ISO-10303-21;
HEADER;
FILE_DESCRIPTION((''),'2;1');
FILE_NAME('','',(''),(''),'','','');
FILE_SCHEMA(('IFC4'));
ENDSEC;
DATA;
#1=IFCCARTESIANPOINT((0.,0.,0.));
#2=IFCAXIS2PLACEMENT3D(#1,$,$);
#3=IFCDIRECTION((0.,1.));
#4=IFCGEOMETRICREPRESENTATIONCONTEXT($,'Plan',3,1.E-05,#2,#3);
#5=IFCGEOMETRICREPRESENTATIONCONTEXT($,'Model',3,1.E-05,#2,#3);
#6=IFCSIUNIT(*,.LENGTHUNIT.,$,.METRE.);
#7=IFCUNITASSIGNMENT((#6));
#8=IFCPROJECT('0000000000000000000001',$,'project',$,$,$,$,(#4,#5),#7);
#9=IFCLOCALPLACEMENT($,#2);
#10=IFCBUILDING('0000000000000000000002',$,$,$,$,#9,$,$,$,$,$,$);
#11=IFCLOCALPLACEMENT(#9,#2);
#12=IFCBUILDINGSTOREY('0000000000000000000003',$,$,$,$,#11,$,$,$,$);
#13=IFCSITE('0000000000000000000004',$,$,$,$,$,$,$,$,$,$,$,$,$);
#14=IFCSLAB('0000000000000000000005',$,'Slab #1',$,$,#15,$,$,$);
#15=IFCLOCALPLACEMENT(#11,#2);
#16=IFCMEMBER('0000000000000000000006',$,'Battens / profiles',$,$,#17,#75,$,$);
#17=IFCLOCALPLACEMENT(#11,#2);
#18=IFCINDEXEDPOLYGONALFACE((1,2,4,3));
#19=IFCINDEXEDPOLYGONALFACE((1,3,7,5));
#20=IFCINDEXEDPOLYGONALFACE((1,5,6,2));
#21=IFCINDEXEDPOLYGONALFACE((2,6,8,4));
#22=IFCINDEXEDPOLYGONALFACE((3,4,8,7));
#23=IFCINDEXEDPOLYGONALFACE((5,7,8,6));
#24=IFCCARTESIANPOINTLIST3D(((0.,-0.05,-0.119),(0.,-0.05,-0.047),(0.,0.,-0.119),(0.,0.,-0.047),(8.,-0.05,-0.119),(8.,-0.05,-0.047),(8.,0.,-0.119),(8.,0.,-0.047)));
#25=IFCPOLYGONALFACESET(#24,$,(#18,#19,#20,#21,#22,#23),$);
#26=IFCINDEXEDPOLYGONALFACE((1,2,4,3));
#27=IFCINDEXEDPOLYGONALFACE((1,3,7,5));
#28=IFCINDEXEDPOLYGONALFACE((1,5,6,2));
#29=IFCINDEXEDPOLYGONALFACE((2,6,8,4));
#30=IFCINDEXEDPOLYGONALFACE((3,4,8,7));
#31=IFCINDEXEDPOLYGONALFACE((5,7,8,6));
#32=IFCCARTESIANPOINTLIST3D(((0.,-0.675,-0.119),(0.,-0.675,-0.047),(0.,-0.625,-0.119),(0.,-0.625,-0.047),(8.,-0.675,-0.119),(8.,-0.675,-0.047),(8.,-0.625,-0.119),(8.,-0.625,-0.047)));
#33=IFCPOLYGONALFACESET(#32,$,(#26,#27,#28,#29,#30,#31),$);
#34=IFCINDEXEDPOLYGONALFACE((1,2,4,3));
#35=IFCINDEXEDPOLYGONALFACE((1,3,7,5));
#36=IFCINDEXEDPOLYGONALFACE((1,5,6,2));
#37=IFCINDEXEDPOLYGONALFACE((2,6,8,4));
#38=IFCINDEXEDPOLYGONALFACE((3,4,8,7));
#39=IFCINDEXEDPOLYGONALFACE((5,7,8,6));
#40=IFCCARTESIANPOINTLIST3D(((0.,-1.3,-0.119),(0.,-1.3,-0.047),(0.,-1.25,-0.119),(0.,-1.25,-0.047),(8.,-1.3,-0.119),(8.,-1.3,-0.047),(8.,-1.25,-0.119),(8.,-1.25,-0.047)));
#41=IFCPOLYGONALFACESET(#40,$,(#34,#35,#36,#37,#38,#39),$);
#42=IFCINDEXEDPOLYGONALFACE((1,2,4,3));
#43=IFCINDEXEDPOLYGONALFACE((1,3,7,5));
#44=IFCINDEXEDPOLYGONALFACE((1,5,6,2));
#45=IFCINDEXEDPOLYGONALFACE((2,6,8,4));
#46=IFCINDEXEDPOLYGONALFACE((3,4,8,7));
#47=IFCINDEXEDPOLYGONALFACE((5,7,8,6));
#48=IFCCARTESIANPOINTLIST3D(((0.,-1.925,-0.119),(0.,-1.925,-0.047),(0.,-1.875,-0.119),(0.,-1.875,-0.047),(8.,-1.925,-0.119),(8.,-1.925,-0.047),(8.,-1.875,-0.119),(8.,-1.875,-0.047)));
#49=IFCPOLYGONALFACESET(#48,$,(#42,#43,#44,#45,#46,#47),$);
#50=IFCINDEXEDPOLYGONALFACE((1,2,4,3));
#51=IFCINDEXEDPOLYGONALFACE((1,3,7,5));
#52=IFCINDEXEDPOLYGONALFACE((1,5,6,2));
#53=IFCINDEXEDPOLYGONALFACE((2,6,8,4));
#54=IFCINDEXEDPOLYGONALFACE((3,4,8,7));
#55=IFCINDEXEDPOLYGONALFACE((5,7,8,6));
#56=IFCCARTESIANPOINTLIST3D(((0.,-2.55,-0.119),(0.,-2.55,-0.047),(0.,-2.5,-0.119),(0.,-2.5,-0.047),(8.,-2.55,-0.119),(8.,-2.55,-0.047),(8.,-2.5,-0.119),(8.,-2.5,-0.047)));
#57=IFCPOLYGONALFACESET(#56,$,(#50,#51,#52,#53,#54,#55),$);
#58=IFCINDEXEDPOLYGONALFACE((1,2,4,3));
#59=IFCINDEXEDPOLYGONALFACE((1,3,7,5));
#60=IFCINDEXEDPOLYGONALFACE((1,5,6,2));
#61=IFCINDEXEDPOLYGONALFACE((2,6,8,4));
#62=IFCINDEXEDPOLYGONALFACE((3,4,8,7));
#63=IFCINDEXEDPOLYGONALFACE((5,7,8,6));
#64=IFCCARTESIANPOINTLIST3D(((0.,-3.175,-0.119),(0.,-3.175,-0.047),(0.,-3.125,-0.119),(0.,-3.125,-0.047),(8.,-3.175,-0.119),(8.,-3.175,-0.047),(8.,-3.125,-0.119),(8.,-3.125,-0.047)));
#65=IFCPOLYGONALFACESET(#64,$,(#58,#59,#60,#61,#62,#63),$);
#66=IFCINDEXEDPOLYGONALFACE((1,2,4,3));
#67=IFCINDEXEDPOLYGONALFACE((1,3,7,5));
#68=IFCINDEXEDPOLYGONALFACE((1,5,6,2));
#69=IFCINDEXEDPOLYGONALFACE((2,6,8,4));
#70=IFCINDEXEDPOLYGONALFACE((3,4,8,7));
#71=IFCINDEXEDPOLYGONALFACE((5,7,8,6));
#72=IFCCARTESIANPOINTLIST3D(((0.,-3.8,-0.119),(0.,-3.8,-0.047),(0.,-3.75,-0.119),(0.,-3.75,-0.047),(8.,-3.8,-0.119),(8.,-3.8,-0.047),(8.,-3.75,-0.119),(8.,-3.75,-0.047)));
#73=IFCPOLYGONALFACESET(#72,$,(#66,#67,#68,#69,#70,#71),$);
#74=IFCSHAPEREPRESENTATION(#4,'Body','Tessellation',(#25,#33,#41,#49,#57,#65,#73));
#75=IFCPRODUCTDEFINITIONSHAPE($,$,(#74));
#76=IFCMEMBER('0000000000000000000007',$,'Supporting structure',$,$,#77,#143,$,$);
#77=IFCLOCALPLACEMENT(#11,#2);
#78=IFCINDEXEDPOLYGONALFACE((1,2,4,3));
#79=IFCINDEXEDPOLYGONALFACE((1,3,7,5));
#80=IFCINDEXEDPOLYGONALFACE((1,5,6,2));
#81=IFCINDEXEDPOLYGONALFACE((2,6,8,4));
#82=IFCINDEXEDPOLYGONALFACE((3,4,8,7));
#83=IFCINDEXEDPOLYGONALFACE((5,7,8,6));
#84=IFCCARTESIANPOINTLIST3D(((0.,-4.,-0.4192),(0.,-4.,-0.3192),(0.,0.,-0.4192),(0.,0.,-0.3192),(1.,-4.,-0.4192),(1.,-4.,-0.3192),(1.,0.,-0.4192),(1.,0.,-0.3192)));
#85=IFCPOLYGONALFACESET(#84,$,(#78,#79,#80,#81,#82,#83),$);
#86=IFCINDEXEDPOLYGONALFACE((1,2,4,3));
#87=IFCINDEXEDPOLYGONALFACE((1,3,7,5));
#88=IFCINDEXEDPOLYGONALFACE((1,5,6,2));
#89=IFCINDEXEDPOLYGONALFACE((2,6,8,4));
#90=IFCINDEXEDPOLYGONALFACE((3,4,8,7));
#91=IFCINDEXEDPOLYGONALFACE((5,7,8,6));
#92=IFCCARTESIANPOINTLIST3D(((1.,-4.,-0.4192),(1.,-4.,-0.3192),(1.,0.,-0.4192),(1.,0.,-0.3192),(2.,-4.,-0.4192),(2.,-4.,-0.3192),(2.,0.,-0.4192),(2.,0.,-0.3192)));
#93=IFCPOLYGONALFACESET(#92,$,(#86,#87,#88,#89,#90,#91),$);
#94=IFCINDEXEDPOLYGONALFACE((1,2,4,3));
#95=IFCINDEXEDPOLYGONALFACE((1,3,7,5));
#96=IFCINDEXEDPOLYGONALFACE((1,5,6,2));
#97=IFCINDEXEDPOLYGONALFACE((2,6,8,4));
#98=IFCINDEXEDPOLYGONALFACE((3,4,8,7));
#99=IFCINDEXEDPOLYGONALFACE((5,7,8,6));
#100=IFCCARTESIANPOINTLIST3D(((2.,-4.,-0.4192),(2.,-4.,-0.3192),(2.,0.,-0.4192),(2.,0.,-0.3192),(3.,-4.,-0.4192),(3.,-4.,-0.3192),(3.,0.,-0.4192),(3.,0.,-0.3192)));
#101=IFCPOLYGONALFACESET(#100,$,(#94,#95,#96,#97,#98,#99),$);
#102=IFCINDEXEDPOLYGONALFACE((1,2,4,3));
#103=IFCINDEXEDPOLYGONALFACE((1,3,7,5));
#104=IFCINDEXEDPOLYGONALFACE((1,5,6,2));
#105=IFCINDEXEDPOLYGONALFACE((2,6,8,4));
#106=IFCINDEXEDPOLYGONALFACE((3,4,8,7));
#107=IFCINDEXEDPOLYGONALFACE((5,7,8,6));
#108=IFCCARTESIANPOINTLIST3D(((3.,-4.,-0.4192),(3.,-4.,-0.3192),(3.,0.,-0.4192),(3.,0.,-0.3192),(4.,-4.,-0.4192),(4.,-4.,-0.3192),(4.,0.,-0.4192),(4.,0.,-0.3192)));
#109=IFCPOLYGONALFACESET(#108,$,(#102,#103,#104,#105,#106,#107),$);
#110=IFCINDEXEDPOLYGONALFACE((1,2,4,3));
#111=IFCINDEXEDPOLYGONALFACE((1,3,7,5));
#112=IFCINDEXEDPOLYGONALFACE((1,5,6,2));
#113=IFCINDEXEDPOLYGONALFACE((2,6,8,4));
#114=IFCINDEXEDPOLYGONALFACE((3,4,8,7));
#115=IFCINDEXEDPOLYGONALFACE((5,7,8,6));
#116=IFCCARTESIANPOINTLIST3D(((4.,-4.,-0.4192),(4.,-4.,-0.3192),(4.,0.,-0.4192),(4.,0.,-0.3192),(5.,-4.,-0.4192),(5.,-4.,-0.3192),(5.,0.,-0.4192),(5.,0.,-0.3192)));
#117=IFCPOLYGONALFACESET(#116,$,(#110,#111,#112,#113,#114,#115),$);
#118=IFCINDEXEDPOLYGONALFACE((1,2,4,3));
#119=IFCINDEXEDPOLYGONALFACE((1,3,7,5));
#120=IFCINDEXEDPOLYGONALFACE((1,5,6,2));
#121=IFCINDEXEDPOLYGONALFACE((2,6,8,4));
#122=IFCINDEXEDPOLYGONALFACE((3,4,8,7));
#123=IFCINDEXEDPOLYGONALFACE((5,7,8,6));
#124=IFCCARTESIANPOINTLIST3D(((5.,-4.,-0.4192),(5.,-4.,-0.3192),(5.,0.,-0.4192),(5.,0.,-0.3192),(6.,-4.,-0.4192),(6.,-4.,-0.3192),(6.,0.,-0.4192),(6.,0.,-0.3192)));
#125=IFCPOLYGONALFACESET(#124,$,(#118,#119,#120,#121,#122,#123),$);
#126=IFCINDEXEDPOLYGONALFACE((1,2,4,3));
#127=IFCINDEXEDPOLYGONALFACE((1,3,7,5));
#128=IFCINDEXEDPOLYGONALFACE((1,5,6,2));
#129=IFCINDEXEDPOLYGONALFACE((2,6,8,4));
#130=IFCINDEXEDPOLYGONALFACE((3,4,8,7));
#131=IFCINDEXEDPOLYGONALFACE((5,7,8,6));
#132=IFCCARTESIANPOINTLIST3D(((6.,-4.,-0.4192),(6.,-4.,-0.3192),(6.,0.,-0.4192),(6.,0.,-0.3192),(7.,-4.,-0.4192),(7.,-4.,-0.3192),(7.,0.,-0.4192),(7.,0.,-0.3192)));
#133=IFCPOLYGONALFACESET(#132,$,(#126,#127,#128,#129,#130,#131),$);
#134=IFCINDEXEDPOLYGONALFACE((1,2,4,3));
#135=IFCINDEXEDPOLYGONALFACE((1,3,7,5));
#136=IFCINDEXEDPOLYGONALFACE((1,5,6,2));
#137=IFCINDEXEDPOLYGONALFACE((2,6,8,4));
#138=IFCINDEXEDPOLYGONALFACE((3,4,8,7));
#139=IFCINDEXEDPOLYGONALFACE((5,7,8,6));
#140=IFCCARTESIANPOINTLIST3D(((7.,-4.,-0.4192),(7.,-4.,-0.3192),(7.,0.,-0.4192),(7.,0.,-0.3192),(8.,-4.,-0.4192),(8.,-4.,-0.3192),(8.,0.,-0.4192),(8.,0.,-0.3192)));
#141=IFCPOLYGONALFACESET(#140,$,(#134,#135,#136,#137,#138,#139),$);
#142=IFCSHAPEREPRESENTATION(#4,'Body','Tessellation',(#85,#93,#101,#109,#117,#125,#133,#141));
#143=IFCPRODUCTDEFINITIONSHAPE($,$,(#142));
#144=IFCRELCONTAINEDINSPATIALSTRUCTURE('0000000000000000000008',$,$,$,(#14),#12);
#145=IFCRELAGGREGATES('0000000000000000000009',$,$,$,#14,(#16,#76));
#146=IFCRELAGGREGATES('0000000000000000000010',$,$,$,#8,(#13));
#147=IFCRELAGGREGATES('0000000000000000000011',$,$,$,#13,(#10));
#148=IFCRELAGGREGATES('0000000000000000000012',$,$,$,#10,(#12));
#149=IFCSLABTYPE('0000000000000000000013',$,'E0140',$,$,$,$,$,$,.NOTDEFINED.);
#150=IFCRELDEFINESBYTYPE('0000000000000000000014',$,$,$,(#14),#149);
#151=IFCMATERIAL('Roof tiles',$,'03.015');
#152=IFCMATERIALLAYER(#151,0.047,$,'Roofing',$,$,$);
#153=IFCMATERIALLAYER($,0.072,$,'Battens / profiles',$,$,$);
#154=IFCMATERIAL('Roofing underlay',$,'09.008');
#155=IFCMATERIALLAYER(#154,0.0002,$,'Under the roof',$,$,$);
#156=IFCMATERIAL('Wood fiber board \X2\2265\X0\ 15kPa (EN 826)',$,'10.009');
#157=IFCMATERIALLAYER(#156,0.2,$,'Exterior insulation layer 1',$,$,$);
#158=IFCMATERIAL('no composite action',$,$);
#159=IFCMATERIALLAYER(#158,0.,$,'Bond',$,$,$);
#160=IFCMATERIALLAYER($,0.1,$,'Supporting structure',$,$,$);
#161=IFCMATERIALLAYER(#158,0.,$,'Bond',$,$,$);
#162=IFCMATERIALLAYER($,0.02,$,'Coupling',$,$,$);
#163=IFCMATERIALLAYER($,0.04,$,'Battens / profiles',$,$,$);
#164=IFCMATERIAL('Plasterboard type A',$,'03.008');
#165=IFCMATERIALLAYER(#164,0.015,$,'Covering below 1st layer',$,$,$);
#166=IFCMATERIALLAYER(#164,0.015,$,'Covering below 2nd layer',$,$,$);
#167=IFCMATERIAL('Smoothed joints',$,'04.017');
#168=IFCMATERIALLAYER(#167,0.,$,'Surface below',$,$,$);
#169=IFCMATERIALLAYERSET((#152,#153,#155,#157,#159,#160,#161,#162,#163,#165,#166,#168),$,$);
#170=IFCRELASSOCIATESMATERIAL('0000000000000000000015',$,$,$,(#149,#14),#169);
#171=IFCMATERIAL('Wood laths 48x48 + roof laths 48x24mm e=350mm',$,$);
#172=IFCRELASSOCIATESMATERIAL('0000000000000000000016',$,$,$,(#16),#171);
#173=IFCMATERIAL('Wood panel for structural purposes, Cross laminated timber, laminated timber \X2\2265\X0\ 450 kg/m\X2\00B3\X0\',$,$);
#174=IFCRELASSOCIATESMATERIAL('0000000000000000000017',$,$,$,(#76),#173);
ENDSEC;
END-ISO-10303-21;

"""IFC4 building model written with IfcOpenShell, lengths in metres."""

from ifc_helpers import new_model, si_unit, direction, frame, frame_2d, origin, place, context, project, spatial, rectangle, extrude, material, layer, layer_set, type_object, element, aggregate, save


model = new_model("IFC4")

# Units and contexts
plan_context = context("Plan", 3, precision=1e-05, world=origin(), true_north=direction((0.0, 1.0)))
model_context = context("Model", 3, precision=1e-05, world=origin(), true_north=direction((0.0, 1.0)))
ifc_project = project(units=[si_unit("LENGTHUNIT", "METRE")], contexts=[plan_context, model_context])

# Site, building, storey
site = spatial("IfcSite", under=ifc_project)
building_placement = place(None, origin())
building = spatial("IfcBuilding", under=site, at=building_placement)
storey_placement = place(building_placement, origin())
storey = spatial("IfcBuildingStorey", under=building, at=storey_placement)

# Slab, members
ifc_material_1 = material(Name="Roof tiles", Category="03.015")
ifc_layer_1 = layer(ifc_material_1, 0.047, Name="Roofing")
ifc_layer_2 = layer(None, 0.072, Name="Battens / profiles")
ifc_material_2 = material(Name="Roofing underlay", Category="09.008")
ifc_layer_3 = layer(ifc_material_2, 0.0002, Name="Under the roof")
ifc_material_3 = material(Name="Wood fiber board ≥ 15kPa (EN 826)", Category="10.009")
ifc_layer_4 = layer(ifc_material_3, 0.2, Name="Exterior insulation layer 1")
ifc_material_4 = material(Name="no composite action")
ifc_layer_5 = layer(ifc_material_4, 0.0, Name="Bond")
ifc_layer_6 = layer(None, 0.1, Name="Supporting structure")
ifc_layer_7 = layer(ifc_material_4, 0.0, Name="Bond")
ifc_layer_8 = layer(None, 0.02, Name="Coupling")
ifc_layer_9 = layer(None, 0.04, Name="Battens / profiles")
ifc_material_5 = material(Name="Plasterboard type A", Category="03.008")
ifc_layer_10 = layer(ifc_material_5, 0.015, Name="Covering below 1st layer")
ifc_layer_11 = layer(ifc_material_5, 0.015, Name="Covering below 2nd layer")
ifc_material_6 = material(Name="Smoothed joints", Category="04.017")
ifc_layer_12 = layer(ifc_material_6, 0.0, Name="Surface below")
ifc_layer_set = layer_set([ifc_layer_1, ifc_layer_2, ifc_layer_3, ifc_layer_4, ifc_layer_5, ifc_layer_6, ifc_layer_7, ifc_layer_8, ifc_layer_9, ifc_layer_10, ifc_layer_11, ifc_layer_12])
slab_type = type_object("IfcSlabType", Name="E0140", PredefinedType="NOTDEFINED", material=ifc_layer_set)
slab_placement = place(None, frame((0.0, 0.0, 0.0), z_axis=(0.0, 0.0, -1.0), x_axis=(1.0, 0.0, 0.0)))
slab = element("IfcSlab", 1, at=slab_placement, inside=storey, type_object=slab_type, material=ifc_layer_set, Name="Slab #1")
ifc_material_7 = material(Name="Wood laths 48x48 + roof laths 48x24mm e=350mm")
member_1_placement = place(slab_placement, origin())
member_1 = element("IfcMember", 2, at=member_1_placement, material=ifc_material_7, Name="Battens / profiles", context=plan_context, shape_type="SweptSolid", body=[
    extrude(rectangle(XDim=0.05, YDim=0.072, at=frame_2d((0.025, 0.036), x_axis=(1.0, 0.0))), frame((0.0, 0.0, 0.047), z_axis=(1.0, 0.0, 0.0), x_axis=(0.0, 1.0, 0.0)), (0.0, 0.0, 1.0), 8.0),
    extrude(rectangle(XDim=0.05, YDim=0.072, at=frame_2d((0.025, 0.036), x_axis=(1.0, 0.0))), frame((0.0, 0.625, 0.047), z_axis=(1.0, 0.0, 0.0), x_axis=(0.0, 1.0, 0.0)), (0.0, 0.0, 1.0), 8.0),
    extrude(rectangle(XDim=0.05, YDim=0.072, at=frame_2d((0.025, 0.036), x_axis=(1.0, 0.0))), frame((0.0, 1.25, 0.047), z_axis=(1.0, 0.0, 0.0), x_axis=(0.0, 1.0, 0.0)), (0.0, 0.0, 1.0), 8.0),
    extrude(rectangle(XDim=0.05, YDim=0.072, at=frame_2d((0.025, 0.036), x_axis=(1.0, 0.0))), frame((0.0, 1.875, 0.047), z_axis=(1.0, 0.0, 0.0), x_axis=(0.0, 1.0, 0.0)), (0.0, 0.0, 1.0), 8.0),
    extrude(rectangle(XDim=0.05, YDim=0.072, at=frame_2d((0.025, 0.036), x_axis=(1.0, 0.0))), frame((0.0, 2.5, 0.047), z_axis=(1.0, 0.0, 0.0), x_axis=(0.0, 1.0, 0.0)), (0.0, 0.0, 1.0), 8.0),
    extrude(rectangle(XDim=0.05, YDim=0.072, at=frame_2d((0.025, 0.036), x_axis=(1.0, 0.0))), frame((0.0, 3.125, 0.047), z_axis=(1.0, 0.0, 0.0), x_axis=(0.0, 1.0, 0.0)), (0.0, 0.0, 1.0), 8.0),
    extrude(rectangle(XDim=0.05, YDim=0.072, at=frame_2d((0.025, 0.036), x_axis=(1.0, 0.0))), frame((0.0, 3.75, 0.047), z_axis=(1.0, 0.0, 0.0), x_axis=(0.0, 1.0, 0.0)), (0.0, 0.0, 1.0), 8.0),
])
ifc_material_8 = material(Name="Wood panel for structural purposes, Cross laminated timber, laminated timber ≥ 450 kg/m³")
member_2_placement = place(slab_placement, origin())
member_2 = element("IfcMember", 3, at=member_2_placement, material=ifc_material_8, Name="Supporting structure", context=plan_context, shape_type="SweptSolid", body=[
    extrude(rectangle(XDim=1.0, YDim=0.1, at=frame_2d((0.5, 0.05), x_axis=(1.0, 0.0))), frame((0.0, 4.0, 0.3192), z_axis=(0.0, -1.0, 0.0), x_axis=(1.0, 0.0, 0.0)), (0.0, 0.0, 1.0), 4.0),
    extrude(rectangle(XDim=1.0, YDim=0.1, at=frame_2d((0.5, 0.05), x_axis=(1.0, 0.0))), frame((1.0, 4.0, 0.3192), z_axis=(0.0, -1.0, 0.0), x_axis=(1.0, 0.0, 0.0)), (0.0, 0.0, 1.0), 4.0),
    extrude(rectangle(XDim=1.0, YDim=0.1, at=frame_2d((0.5, 0.05), x_axis=(1.0, 0.0))), frame((2.0, 4.0, 0.3192), z_axis=(0.0, -1.0, 0.0), x_axis=(1.0, 0.0, 0.0)), (0.0, 0.0, 1.0), 4.0),
    extrude(rectangle(XDim=1.0, YDim=0.1, at=frame_2d((0.5, 0.05), x_axis=(1.0, 0.0))), frame((3.0, 4.0, 0.3192), z_axis=(0.0, -1.0, 0.0), x_axis=(1.0, 0.0, 0.0)), (0.0, 0.0, 1.0), 4.0),
    extrude(rectangle(XDim=1.0, YDim=0.1, at=frame_2d((0.5, 0.05), x_axis=(1.0, 0.0))), frame((4.0, 4.0, 0.3192), z_axis=(0.0, -1.0, 0.0), x_axis=(1.0, 0.0, 0.0)), (0.0, 0.0, 1.0), 4.0),
    extrude(rectangle(XDim=1.0, YDim=0.1, at=frame_2d((0.5, 0.05), x_axis=(1.0, 0.0))), frame((5.0, 4.0, 0.3192), z_axis=(0.0, -1.0, 0.0), x_axis=(1.0, 0.0, 0.0)), (0.0, 0.0, 1.0), 4.0),
    extrude(rectangle(XDim=1.0, YDim=0.1, at=frame_2d((0.5, 0.05), x_axis=(1.0, 0.0))), frame((6.0, 4.0, 0.3192), z_axis=(0.0, -1.0, 0.0), x_axis=(1.0, 0.0, 0.0)), (0.0, 0.0, 1.0), 4.0),
    extrude(rectangle(XDim=1.0, YDim=0.1, at=frame_2d((0.5, 0.05), x_axis=(1.0, 0.0))), frame((7.0, 4.0, 0.3192), z_axis=(0.0, -1.0, 0.0), x_axis=(1.0, 0.0, 0.0)), (0.0, 0.0, 1.0), 4.0),
])
aggregate(slab, [member_1, member_2])

save(model, "model.ifc")
